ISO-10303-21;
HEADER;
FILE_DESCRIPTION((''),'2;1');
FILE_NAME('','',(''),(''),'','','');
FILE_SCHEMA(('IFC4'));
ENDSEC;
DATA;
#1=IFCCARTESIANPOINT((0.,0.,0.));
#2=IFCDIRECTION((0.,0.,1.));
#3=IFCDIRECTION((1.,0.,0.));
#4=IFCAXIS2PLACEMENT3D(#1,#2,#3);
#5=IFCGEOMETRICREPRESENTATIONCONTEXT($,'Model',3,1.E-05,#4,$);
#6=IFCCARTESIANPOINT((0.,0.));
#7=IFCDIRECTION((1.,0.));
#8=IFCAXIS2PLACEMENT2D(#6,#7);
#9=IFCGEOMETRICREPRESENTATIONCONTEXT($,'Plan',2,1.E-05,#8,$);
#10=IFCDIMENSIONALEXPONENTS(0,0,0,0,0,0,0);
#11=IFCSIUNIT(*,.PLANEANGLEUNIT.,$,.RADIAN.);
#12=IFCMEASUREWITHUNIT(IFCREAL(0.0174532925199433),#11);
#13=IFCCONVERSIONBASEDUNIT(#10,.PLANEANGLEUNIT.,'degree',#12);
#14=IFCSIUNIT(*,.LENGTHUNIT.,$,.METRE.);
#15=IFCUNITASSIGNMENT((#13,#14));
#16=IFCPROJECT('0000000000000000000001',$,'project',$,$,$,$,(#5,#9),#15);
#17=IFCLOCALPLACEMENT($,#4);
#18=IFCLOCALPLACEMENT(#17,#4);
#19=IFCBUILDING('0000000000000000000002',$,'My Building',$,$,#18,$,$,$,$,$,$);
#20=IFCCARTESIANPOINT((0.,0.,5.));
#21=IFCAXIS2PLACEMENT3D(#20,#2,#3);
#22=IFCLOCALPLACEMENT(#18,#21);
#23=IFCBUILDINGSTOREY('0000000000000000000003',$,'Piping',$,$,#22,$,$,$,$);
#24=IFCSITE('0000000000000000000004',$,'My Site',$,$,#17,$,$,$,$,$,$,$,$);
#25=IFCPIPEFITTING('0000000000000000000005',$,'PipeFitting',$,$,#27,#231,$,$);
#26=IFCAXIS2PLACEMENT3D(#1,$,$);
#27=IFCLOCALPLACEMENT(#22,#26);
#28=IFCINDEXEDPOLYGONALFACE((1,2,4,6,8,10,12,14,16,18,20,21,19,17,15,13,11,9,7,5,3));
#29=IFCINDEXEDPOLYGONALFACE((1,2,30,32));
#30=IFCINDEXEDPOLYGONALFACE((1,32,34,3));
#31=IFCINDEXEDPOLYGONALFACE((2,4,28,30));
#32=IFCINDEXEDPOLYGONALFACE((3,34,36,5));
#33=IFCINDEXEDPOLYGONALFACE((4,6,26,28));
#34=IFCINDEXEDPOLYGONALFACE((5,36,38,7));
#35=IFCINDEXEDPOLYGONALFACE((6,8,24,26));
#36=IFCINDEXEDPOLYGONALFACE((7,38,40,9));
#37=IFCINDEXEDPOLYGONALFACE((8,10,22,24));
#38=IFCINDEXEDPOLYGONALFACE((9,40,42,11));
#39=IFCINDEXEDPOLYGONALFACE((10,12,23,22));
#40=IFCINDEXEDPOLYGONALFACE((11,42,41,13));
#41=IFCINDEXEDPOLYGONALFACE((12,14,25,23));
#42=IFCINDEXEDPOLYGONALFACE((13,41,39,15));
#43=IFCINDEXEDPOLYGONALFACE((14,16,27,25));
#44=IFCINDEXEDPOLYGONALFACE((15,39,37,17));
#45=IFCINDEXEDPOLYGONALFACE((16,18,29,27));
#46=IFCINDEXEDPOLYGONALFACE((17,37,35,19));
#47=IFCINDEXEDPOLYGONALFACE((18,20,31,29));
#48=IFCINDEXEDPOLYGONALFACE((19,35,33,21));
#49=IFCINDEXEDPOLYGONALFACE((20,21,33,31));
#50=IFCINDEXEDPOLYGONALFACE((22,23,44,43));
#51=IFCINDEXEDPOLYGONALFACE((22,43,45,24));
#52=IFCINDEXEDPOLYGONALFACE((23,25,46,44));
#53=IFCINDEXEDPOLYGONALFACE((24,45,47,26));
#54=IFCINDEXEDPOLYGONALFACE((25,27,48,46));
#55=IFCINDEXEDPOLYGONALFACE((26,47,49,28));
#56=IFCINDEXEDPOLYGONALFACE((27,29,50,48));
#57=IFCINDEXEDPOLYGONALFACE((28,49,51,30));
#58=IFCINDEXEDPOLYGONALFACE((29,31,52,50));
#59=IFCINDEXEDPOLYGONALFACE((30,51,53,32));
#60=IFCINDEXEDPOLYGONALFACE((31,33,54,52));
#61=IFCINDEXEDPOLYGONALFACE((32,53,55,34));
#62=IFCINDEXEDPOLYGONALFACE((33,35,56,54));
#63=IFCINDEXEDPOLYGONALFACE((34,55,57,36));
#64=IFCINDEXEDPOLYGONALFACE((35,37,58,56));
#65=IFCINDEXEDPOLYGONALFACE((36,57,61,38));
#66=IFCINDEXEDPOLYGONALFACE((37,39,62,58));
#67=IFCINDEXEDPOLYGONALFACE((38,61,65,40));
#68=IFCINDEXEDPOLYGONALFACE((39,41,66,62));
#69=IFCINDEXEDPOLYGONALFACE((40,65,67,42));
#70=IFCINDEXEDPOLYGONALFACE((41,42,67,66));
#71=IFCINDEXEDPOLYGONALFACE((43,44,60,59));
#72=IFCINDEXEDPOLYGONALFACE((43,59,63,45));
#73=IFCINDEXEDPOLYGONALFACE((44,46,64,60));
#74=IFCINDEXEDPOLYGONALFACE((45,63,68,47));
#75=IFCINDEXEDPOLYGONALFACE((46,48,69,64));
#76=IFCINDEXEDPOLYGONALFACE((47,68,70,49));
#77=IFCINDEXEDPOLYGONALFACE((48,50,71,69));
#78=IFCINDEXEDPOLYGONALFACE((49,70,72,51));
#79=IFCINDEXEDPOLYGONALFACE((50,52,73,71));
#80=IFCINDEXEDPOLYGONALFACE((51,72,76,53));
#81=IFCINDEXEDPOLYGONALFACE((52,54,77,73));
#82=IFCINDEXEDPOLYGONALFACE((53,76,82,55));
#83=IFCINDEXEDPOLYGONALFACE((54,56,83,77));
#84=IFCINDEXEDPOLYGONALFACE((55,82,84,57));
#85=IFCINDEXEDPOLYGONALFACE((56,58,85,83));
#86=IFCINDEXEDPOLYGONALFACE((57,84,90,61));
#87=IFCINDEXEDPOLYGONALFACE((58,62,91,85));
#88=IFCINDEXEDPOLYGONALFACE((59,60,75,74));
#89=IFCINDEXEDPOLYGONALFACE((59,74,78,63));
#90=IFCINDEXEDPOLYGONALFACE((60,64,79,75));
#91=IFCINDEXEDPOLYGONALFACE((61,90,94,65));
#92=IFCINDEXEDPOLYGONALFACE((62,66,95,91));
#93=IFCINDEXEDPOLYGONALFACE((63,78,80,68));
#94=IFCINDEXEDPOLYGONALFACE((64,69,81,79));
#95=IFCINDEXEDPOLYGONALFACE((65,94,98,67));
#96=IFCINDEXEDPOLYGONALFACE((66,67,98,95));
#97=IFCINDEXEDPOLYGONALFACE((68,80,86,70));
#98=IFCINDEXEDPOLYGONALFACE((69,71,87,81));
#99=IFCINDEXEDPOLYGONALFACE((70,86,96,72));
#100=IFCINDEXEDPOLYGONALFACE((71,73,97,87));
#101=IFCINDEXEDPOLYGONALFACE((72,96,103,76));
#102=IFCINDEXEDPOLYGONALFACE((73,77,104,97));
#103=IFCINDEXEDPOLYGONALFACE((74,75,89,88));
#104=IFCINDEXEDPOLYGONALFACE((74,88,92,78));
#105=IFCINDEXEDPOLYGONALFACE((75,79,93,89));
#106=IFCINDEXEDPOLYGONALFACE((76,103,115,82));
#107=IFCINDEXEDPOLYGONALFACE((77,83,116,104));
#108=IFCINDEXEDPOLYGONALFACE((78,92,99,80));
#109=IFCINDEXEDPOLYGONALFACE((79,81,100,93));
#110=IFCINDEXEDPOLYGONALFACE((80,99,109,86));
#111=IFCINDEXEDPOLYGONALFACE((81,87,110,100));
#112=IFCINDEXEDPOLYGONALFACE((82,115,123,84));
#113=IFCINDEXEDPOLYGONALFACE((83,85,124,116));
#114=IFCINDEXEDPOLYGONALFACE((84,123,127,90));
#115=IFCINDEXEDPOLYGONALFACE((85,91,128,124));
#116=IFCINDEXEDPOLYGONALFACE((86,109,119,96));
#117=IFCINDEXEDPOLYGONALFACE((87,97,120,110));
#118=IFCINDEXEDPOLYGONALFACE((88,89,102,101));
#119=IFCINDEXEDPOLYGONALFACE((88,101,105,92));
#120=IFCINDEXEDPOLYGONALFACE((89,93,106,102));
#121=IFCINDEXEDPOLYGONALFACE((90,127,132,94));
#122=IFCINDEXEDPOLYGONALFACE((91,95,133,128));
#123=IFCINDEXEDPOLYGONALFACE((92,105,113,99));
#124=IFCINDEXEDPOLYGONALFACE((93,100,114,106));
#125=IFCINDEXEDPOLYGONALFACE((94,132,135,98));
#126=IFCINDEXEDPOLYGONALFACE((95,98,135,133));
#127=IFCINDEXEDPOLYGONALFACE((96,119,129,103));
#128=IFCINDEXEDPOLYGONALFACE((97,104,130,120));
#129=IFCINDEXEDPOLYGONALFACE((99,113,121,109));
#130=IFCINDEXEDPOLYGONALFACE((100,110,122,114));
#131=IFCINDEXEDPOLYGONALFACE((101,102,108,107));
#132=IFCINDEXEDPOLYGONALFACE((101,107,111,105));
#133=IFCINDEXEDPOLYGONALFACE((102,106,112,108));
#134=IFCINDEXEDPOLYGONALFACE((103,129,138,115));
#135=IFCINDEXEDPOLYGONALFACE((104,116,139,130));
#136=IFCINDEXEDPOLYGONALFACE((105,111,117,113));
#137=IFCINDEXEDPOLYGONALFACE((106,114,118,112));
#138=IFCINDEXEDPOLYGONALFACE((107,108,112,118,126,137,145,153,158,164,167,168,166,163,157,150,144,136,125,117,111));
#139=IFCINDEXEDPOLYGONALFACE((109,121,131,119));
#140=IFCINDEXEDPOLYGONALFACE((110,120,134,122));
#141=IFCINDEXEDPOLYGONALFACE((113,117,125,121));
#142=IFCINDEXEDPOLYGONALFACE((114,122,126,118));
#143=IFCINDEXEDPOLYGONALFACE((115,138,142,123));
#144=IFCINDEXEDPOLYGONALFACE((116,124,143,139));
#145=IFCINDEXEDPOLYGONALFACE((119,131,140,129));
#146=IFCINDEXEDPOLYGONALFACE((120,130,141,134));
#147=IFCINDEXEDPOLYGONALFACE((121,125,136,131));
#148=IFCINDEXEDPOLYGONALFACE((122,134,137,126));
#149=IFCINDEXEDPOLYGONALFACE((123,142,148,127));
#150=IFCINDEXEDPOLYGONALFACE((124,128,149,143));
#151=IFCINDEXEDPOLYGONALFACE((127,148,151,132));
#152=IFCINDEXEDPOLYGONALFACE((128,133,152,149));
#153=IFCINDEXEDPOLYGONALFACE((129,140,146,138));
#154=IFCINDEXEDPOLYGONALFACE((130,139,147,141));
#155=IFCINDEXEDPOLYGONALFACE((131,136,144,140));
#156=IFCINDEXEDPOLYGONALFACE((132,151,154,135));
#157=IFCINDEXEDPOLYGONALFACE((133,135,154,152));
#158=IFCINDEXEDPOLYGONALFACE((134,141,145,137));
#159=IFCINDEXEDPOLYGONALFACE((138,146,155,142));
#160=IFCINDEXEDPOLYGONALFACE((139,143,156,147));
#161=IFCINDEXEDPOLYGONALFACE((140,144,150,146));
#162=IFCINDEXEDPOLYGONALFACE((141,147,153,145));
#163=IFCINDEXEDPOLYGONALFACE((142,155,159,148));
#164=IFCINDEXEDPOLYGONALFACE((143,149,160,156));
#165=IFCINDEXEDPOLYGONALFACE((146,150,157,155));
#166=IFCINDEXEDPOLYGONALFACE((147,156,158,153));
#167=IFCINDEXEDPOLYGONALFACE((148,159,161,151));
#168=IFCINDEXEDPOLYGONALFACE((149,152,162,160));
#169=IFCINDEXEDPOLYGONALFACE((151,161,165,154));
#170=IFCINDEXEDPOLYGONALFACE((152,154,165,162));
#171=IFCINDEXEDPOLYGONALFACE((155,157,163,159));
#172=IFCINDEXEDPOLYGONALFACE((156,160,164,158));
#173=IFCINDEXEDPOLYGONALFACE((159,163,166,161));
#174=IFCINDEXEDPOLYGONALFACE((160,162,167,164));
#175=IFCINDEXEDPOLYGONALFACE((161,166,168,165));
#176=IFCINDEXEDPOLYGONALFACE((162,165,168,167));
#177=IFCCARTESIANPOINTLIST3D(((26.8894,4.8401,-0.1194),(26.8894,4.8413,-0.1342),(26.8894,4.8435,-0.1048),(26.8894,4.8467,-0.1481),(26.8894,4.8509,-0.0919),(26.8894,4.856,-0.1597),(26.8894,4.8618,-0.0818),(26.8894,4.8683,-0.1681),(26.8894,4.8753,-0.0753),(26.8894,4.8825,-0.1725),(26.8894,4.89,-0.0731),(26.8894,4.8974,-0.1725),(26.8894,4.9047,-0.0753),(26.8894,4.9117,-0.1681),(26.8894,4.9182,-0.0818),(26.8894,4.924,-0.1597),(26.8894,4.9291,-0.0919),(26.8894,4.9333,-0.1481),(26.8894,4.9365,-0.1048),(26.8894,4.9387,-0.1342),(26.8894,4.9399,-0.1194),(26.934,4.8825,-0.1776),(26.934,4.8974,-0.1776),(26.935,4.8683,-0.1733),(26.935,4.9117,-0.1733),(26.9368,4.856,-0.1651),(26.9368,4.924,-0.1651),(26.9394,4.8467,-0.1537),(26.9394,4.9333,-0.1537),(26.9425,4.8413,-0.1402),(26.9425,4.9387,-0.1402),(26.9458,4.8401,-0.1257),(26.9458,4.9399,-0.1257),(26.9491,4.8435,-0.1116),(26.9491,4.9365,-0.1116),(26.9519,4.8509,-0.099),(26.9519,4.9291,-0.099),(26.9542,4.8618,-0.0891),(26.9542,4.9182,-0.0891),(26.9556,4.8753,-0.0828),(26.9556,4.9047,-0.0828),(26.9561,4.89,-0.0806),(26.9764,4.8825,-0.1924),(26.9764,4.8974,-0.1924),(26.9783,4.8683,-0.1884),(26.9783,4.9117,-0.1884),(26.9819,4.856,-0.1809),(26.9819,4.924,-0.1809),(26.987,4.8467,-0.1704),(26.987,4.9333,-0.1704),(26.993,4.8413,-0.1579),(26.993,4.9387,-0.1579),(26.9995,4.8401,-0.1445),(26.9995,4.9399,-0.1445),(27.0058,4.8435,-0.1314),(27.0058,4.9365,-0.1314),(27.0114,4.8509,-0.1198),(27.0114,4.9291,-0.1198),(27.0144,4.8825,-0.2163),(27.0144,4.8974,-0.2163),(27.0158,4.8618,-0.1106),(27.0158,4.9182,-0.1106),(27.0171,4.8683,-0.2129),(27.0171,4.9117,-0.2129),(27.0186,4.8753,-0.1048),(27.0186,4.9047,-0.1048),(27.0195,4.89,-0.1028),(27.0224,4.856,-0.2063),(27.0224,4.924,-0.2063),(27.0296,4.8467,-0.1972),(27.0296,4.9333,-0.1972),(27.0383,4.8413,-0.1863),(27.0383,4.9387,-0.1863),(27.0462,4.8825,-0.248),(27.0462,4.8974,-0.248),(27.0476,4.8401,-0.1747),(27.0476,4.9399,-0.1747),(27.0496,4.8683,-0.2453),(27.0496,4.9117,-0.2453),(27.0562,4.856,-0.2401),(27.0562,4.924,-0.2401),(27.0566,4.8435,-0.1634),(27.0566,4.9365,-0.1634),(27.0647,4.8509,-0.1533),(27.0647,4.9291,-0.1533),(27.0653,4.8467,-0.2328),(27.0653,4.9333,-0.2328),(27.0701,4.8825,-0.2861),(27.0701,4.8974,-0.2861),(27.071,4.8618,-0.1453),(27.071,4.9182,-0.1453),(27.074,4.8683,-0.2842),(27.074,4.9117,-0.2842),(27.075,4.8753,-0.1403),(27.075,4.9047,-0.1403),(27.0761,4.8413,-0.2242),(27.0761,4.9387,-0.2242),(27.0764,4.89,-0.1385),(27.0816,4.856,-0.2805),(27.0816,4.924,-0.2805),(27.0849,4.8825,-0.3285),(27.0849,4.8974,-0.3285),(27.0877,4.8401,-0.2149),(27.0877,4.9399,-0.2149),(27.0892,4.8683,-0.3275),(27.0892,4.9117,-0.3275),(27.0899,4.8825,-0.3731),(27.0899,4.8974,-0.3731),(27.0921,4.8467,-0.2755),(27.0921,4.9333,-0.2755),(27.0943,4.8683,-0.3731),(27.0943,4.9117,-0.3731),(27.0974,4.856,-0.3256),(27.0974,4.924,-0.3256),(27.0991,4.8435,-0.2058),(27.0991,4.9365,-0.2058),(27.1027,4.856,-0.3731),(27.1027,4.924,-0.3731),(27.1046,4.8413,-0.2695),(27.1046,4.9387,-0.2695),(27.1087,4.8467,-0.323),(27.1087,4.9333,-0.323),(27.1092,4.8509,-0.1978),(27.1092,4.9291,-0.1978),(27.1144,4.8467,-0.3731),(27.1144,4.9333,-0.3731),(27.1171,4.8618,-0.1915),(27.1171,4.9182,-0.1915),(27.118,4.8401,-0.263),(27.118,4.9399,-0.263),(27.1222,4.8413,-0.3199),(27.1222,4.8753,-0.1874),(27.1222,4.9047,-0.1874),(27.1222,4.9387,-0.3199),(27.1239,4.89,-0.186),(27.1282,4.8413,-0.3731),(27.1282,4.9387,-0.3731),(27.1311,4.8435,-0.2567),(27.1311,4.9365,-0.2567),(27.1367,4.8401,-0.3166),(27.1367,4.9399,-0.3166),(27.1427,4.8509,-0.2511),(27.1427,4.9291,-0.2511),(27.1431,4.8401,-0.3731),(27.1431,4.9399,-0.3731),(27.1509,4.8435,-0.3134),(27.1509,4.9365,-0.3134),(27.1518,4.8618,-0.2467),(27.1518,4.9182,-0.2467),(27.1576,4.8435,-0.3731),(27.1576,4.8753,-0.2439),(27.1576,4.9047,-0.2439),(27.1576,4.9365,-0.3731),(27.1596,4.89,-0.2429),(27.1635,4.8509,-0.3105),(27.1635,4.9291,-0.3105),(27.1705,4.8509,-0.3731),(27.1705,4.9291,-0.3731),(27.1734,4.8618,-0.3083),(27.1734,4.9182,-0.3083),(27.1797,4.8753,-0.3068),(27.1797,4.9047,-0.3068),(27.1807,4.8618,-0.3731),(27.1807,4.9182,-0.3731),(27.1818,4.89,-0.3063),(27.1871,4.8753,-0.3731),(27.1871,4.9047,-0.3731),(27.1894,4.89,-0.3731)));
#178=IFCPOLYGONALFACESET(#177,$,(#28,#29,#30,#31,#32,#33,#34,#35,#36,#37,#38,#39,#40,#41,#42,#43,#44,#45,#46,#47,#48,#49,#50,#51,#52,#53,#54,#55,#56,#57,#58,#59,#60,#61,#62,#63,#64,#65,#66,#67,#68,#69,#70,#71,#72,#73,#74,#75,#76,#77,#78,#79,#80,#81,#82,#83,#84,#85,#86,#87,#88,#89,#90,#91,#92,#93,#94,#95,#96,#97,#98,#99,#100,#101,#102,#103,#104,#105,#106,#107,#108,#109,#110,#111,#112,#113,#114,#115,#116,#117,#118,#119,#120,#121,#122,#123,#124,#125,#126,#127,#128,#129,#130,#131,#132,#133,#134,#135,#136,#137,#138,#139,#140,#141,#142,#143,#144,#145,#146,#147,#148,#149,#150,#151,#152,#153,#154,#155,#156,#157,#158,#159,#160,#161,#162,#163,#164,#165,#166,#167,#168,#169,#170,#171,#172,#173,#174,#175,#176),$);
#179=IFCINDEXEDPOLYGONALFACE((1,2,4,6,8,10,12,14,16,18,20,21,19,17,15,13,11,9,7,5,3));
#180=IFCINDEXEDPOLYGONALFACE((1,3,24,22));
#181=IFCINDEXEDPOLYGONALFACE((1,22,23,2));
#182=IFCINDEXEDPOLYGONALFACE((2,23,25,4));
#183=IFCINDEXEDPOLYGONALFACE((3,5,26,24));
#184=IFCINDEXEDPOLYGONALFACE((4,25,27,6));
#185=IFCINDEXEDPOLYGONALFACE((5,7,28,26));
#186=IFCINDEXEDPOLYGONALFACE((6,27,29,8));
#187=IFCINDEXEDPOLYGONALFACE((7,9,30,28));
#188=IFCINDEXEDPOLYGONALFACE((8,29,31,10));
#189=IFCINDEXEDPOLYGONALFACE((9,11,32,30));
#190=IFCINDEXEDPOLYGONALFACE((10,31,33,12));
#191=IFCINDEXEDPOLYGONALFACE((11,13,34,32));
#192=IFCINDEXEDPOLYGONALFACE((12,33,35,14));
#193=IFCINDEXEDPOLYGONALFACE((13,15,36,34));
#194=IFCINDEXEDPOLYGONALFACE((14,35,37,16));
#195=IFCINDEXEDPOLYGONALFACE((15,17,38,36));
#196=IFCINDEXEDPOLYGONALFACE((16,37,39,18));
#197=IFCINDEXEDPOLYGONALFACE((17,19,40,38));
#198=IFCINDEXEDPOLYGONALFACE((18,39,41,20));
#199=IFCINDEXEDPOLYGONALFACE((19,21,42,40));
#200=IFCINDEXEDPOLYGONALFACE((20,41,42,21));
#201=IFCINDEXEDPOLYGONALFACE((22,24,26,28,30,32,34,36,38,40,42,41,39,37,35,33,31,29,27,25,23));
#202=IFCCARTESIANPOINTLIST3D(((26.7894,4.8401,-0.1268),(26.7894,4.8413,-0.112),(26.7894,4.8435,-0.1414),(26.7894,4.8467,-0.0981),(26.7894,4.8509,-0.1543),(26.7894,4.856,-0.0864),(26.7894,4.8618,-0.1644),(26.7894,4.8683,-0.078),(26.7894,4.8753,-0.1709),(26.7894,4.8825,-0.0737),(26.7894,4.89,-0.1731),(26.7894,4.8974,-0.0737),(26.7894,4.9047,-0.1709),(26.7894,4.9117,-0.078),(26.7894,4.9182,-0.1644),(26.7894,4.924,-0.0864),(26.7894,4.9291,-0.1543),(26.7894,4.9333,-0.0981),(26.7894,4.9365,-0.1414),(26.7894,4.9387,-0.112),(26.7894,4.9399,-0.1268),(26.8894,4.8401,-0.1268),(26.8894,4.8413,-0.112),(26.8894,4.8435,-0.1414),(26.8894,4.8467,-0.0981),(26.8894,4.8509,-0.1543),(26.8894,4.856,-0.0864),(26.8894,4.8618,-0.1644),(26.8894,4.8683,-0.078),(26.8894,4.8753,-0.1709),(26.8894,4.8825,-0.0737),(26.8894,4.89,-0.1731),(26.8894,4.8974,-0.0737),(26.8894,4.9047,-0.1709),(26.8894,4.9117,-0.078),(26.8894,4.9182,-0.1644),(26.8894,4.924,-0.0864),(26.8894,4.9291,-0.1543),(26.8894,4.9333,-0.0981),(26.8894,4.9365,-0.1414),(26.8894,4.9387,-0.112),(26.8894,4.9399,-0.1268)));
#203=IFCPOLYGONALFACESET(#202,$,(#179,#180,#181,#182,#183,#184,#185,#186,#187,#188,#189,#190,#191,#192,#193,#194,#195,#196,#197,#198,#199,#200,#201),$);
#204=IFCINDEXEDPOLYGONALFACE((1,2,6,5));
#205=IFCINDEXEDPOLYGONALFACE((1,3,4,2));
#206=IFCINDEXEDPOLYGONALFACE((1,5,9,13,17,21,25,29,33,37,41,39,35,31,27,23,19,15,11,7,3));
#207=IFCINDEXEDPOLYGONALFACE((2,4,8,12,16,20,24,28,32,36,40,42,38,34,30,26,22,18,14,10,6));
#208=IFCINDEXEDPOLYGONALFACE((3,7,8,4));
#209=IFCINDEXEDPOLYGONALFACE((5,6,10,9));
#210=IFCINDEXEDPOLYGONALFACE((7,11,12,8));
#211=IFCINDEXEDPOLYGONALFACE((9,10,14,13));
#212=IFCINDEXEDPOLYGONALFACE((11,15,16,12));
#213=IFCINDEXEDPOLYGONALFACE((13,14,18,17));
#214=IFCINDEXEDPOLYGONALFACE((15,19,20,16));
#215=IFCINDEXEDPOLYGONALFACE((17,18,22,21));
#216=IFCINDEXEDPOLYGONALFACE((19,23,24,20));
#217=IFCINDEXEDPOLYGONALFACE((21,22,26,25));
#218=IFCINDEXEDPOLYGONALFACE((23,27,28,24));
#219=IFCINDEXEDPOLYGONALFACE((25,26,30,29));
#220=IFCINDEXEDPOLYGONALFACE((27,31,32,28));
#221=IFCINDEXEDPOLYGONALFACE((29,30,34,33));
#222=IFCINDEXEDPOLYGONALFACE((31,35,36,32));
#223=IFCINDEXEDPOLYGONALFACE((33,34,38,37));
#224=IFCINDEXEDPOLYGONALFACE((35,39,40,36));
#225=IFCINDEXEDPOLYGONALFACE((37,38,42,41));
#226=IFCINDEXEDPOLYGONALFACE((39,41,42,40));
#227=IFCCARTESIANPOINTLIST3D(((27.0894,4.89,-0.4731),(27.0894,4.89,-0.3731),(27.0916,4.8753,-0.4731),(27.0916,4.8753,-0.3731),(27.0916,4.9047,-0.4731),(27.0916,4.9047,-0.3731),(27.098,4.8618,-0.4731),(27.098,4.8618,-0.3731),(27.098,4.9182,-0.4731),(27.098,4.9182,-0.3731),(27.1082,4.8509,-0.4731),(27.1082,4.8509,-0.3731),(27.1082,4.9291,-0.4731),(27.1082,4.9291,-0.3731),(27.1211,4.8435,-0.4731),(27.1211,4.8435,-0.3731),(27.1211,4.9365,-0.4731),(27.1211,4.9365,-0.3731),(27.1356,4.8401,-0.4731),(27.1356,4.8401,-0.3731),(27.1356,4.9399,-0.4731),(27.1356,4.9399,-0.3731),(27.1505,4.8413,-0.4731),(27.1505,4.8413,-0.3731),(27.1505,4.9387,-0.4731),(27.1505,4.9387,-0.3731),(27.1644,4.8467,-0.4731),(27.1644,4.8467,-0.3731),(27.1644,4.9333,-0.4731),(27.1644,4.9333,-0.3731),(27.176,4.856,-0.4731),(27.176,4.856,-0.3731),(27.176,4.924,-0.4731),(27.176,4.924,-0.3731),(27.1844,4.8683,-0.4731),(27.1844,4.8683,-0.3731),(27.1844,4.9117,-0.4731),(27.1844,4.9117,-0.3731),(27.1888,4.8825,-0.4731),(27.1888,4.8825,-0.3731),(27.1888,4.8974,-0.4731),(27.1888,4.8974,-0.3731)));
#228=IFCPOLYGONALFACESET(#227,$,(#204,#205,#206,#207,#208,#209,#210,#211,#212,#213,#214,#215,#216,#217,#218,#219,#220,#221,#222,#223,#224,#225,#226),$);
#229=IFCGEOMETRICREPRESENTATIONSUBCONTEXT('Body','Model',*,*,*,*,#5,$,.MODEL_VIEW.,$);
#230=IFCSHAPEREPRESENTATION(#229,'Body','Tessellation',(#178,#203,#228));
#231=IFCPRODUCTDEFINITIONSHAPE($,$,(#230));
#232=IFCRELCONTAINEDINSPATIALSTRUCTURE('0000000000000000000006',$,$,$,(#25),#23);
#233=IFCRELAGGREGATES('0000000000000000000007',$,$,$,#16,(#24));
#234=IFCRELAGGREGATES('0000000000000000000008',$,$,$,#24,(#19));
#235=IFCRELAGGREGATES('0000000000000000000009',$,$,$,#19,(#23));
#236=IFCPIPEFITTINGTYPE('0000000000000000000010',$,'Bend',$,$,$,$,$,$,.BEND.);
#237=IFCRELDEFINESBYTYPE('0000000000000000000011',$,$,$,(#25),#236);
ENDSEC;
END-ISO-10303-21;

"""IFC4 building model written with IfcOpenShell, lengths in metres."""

from ifc_helpers import new_model, entity, si_unit, converted_unit, frame, origin_with_axes, origin_2d_with_axis, place, context, subcontext, project, spatial, circle, extrude, source, transform, mapped, type_object, type_shapes, element, save


model = new_model("IFC4")

# Units and contexts
model_context = context("Model", 3, precision=1e-05, world=origin_with_axes())
plan_context = context("Plan", 2, precision=1e-05, world=origin_2d_with_axis())
body_context = subcontext(model_context, "Body", "Model", "MODEL_VIEW")
ifc_project = project(units=[converted_unit("PLANEANGLEUNIT", "degree", entity("IfcReal", 0.0174532925199433), si_unit("PLANEANGLEUNIT", "RADIAN"), dimensions=[0, 0, 0, 0, 0, 0, 0]), si_unit("LENGTHUNIT", "METRE")], contexts=[model_context, plan_context])

# Site, building, storey
site_placement = place(None, origin_with_axes())
site = spatial("IfcSite", under=ifc_project, at=site_placement, Name="My Site")
building_placement = place(site_placement, origin_with_axes())
building = spatial("IfcBuilding", under=site, at=building_placement, Name="My Building")
storey_placement = place(building_placement, frame((0.0, 0.0, 5.0), z_axis=(0.0, 0.0, 1.0), x_axis=(1.0, 0.0, 0.0)))
storey = spatial("IfcBuildingStorey", under=building, at=storey_placement, Name="Piping")

# Pipe fitting
pipe_fitting_type_1 = type_object("IfcPipeFittingType", Name="Bend", PredefinedType="BEND")
shared_shape = source(origin_with_axes(), body_context, "Body", "SolidModel", [
    entity("IfcSweptDiskSolid", entity("IfcIndexedPolyCurve", entity("IfcCartesianPointList3D", [[0.0, 0.0, -0.1], [0.0732, 0.0, -0.2768], [0.25, 0.0, -0.35]]), [entity("IfcArcIndex", [1, 2, 3])]), 0.05),
    extrude(circle(Radius=0.05), origin_with_axes(), (0.0, 0.0, -1.0), 0.1),
    extrude(circle(Radius=0.05), frame((0.25, 0.0, -0.35), z_axis=(1.0, 0.0, 0.0), x_axis=(0.0, 0.0, 1.0)), (0.0, 0.0, 1.0), 0.1),
])
type_shapes(pipe_fitting_type_1, [shared_shape])
for number, where, z_axis, x_axis, name in (
    (1, (26.7894, 4.89, -0.1231), (-1.0, -0.000001, 0.0), (0.0, 0.0, -1.0), "PipeFitting"),
):
    element("IfcPipeFitting", number, at=place(storey_placement, frame(where, z_axis=z_axis, x_axis=x_axis)), inside=storey, type_object=pipe_fitting_type_1, Name=name, context=body_context, shape_type="MappedRepresentation", body=[
        mapped(shared_shape, transform((0.0, 0.0, 0.0), x_axis=(1.0, 0.0, 0.0), y_axis=(0.0, 1.0, 0.0), z_axis=(0.0, 0.0, 1.0), scale=1.0)),
    ])

save(model, "model.ifc")
